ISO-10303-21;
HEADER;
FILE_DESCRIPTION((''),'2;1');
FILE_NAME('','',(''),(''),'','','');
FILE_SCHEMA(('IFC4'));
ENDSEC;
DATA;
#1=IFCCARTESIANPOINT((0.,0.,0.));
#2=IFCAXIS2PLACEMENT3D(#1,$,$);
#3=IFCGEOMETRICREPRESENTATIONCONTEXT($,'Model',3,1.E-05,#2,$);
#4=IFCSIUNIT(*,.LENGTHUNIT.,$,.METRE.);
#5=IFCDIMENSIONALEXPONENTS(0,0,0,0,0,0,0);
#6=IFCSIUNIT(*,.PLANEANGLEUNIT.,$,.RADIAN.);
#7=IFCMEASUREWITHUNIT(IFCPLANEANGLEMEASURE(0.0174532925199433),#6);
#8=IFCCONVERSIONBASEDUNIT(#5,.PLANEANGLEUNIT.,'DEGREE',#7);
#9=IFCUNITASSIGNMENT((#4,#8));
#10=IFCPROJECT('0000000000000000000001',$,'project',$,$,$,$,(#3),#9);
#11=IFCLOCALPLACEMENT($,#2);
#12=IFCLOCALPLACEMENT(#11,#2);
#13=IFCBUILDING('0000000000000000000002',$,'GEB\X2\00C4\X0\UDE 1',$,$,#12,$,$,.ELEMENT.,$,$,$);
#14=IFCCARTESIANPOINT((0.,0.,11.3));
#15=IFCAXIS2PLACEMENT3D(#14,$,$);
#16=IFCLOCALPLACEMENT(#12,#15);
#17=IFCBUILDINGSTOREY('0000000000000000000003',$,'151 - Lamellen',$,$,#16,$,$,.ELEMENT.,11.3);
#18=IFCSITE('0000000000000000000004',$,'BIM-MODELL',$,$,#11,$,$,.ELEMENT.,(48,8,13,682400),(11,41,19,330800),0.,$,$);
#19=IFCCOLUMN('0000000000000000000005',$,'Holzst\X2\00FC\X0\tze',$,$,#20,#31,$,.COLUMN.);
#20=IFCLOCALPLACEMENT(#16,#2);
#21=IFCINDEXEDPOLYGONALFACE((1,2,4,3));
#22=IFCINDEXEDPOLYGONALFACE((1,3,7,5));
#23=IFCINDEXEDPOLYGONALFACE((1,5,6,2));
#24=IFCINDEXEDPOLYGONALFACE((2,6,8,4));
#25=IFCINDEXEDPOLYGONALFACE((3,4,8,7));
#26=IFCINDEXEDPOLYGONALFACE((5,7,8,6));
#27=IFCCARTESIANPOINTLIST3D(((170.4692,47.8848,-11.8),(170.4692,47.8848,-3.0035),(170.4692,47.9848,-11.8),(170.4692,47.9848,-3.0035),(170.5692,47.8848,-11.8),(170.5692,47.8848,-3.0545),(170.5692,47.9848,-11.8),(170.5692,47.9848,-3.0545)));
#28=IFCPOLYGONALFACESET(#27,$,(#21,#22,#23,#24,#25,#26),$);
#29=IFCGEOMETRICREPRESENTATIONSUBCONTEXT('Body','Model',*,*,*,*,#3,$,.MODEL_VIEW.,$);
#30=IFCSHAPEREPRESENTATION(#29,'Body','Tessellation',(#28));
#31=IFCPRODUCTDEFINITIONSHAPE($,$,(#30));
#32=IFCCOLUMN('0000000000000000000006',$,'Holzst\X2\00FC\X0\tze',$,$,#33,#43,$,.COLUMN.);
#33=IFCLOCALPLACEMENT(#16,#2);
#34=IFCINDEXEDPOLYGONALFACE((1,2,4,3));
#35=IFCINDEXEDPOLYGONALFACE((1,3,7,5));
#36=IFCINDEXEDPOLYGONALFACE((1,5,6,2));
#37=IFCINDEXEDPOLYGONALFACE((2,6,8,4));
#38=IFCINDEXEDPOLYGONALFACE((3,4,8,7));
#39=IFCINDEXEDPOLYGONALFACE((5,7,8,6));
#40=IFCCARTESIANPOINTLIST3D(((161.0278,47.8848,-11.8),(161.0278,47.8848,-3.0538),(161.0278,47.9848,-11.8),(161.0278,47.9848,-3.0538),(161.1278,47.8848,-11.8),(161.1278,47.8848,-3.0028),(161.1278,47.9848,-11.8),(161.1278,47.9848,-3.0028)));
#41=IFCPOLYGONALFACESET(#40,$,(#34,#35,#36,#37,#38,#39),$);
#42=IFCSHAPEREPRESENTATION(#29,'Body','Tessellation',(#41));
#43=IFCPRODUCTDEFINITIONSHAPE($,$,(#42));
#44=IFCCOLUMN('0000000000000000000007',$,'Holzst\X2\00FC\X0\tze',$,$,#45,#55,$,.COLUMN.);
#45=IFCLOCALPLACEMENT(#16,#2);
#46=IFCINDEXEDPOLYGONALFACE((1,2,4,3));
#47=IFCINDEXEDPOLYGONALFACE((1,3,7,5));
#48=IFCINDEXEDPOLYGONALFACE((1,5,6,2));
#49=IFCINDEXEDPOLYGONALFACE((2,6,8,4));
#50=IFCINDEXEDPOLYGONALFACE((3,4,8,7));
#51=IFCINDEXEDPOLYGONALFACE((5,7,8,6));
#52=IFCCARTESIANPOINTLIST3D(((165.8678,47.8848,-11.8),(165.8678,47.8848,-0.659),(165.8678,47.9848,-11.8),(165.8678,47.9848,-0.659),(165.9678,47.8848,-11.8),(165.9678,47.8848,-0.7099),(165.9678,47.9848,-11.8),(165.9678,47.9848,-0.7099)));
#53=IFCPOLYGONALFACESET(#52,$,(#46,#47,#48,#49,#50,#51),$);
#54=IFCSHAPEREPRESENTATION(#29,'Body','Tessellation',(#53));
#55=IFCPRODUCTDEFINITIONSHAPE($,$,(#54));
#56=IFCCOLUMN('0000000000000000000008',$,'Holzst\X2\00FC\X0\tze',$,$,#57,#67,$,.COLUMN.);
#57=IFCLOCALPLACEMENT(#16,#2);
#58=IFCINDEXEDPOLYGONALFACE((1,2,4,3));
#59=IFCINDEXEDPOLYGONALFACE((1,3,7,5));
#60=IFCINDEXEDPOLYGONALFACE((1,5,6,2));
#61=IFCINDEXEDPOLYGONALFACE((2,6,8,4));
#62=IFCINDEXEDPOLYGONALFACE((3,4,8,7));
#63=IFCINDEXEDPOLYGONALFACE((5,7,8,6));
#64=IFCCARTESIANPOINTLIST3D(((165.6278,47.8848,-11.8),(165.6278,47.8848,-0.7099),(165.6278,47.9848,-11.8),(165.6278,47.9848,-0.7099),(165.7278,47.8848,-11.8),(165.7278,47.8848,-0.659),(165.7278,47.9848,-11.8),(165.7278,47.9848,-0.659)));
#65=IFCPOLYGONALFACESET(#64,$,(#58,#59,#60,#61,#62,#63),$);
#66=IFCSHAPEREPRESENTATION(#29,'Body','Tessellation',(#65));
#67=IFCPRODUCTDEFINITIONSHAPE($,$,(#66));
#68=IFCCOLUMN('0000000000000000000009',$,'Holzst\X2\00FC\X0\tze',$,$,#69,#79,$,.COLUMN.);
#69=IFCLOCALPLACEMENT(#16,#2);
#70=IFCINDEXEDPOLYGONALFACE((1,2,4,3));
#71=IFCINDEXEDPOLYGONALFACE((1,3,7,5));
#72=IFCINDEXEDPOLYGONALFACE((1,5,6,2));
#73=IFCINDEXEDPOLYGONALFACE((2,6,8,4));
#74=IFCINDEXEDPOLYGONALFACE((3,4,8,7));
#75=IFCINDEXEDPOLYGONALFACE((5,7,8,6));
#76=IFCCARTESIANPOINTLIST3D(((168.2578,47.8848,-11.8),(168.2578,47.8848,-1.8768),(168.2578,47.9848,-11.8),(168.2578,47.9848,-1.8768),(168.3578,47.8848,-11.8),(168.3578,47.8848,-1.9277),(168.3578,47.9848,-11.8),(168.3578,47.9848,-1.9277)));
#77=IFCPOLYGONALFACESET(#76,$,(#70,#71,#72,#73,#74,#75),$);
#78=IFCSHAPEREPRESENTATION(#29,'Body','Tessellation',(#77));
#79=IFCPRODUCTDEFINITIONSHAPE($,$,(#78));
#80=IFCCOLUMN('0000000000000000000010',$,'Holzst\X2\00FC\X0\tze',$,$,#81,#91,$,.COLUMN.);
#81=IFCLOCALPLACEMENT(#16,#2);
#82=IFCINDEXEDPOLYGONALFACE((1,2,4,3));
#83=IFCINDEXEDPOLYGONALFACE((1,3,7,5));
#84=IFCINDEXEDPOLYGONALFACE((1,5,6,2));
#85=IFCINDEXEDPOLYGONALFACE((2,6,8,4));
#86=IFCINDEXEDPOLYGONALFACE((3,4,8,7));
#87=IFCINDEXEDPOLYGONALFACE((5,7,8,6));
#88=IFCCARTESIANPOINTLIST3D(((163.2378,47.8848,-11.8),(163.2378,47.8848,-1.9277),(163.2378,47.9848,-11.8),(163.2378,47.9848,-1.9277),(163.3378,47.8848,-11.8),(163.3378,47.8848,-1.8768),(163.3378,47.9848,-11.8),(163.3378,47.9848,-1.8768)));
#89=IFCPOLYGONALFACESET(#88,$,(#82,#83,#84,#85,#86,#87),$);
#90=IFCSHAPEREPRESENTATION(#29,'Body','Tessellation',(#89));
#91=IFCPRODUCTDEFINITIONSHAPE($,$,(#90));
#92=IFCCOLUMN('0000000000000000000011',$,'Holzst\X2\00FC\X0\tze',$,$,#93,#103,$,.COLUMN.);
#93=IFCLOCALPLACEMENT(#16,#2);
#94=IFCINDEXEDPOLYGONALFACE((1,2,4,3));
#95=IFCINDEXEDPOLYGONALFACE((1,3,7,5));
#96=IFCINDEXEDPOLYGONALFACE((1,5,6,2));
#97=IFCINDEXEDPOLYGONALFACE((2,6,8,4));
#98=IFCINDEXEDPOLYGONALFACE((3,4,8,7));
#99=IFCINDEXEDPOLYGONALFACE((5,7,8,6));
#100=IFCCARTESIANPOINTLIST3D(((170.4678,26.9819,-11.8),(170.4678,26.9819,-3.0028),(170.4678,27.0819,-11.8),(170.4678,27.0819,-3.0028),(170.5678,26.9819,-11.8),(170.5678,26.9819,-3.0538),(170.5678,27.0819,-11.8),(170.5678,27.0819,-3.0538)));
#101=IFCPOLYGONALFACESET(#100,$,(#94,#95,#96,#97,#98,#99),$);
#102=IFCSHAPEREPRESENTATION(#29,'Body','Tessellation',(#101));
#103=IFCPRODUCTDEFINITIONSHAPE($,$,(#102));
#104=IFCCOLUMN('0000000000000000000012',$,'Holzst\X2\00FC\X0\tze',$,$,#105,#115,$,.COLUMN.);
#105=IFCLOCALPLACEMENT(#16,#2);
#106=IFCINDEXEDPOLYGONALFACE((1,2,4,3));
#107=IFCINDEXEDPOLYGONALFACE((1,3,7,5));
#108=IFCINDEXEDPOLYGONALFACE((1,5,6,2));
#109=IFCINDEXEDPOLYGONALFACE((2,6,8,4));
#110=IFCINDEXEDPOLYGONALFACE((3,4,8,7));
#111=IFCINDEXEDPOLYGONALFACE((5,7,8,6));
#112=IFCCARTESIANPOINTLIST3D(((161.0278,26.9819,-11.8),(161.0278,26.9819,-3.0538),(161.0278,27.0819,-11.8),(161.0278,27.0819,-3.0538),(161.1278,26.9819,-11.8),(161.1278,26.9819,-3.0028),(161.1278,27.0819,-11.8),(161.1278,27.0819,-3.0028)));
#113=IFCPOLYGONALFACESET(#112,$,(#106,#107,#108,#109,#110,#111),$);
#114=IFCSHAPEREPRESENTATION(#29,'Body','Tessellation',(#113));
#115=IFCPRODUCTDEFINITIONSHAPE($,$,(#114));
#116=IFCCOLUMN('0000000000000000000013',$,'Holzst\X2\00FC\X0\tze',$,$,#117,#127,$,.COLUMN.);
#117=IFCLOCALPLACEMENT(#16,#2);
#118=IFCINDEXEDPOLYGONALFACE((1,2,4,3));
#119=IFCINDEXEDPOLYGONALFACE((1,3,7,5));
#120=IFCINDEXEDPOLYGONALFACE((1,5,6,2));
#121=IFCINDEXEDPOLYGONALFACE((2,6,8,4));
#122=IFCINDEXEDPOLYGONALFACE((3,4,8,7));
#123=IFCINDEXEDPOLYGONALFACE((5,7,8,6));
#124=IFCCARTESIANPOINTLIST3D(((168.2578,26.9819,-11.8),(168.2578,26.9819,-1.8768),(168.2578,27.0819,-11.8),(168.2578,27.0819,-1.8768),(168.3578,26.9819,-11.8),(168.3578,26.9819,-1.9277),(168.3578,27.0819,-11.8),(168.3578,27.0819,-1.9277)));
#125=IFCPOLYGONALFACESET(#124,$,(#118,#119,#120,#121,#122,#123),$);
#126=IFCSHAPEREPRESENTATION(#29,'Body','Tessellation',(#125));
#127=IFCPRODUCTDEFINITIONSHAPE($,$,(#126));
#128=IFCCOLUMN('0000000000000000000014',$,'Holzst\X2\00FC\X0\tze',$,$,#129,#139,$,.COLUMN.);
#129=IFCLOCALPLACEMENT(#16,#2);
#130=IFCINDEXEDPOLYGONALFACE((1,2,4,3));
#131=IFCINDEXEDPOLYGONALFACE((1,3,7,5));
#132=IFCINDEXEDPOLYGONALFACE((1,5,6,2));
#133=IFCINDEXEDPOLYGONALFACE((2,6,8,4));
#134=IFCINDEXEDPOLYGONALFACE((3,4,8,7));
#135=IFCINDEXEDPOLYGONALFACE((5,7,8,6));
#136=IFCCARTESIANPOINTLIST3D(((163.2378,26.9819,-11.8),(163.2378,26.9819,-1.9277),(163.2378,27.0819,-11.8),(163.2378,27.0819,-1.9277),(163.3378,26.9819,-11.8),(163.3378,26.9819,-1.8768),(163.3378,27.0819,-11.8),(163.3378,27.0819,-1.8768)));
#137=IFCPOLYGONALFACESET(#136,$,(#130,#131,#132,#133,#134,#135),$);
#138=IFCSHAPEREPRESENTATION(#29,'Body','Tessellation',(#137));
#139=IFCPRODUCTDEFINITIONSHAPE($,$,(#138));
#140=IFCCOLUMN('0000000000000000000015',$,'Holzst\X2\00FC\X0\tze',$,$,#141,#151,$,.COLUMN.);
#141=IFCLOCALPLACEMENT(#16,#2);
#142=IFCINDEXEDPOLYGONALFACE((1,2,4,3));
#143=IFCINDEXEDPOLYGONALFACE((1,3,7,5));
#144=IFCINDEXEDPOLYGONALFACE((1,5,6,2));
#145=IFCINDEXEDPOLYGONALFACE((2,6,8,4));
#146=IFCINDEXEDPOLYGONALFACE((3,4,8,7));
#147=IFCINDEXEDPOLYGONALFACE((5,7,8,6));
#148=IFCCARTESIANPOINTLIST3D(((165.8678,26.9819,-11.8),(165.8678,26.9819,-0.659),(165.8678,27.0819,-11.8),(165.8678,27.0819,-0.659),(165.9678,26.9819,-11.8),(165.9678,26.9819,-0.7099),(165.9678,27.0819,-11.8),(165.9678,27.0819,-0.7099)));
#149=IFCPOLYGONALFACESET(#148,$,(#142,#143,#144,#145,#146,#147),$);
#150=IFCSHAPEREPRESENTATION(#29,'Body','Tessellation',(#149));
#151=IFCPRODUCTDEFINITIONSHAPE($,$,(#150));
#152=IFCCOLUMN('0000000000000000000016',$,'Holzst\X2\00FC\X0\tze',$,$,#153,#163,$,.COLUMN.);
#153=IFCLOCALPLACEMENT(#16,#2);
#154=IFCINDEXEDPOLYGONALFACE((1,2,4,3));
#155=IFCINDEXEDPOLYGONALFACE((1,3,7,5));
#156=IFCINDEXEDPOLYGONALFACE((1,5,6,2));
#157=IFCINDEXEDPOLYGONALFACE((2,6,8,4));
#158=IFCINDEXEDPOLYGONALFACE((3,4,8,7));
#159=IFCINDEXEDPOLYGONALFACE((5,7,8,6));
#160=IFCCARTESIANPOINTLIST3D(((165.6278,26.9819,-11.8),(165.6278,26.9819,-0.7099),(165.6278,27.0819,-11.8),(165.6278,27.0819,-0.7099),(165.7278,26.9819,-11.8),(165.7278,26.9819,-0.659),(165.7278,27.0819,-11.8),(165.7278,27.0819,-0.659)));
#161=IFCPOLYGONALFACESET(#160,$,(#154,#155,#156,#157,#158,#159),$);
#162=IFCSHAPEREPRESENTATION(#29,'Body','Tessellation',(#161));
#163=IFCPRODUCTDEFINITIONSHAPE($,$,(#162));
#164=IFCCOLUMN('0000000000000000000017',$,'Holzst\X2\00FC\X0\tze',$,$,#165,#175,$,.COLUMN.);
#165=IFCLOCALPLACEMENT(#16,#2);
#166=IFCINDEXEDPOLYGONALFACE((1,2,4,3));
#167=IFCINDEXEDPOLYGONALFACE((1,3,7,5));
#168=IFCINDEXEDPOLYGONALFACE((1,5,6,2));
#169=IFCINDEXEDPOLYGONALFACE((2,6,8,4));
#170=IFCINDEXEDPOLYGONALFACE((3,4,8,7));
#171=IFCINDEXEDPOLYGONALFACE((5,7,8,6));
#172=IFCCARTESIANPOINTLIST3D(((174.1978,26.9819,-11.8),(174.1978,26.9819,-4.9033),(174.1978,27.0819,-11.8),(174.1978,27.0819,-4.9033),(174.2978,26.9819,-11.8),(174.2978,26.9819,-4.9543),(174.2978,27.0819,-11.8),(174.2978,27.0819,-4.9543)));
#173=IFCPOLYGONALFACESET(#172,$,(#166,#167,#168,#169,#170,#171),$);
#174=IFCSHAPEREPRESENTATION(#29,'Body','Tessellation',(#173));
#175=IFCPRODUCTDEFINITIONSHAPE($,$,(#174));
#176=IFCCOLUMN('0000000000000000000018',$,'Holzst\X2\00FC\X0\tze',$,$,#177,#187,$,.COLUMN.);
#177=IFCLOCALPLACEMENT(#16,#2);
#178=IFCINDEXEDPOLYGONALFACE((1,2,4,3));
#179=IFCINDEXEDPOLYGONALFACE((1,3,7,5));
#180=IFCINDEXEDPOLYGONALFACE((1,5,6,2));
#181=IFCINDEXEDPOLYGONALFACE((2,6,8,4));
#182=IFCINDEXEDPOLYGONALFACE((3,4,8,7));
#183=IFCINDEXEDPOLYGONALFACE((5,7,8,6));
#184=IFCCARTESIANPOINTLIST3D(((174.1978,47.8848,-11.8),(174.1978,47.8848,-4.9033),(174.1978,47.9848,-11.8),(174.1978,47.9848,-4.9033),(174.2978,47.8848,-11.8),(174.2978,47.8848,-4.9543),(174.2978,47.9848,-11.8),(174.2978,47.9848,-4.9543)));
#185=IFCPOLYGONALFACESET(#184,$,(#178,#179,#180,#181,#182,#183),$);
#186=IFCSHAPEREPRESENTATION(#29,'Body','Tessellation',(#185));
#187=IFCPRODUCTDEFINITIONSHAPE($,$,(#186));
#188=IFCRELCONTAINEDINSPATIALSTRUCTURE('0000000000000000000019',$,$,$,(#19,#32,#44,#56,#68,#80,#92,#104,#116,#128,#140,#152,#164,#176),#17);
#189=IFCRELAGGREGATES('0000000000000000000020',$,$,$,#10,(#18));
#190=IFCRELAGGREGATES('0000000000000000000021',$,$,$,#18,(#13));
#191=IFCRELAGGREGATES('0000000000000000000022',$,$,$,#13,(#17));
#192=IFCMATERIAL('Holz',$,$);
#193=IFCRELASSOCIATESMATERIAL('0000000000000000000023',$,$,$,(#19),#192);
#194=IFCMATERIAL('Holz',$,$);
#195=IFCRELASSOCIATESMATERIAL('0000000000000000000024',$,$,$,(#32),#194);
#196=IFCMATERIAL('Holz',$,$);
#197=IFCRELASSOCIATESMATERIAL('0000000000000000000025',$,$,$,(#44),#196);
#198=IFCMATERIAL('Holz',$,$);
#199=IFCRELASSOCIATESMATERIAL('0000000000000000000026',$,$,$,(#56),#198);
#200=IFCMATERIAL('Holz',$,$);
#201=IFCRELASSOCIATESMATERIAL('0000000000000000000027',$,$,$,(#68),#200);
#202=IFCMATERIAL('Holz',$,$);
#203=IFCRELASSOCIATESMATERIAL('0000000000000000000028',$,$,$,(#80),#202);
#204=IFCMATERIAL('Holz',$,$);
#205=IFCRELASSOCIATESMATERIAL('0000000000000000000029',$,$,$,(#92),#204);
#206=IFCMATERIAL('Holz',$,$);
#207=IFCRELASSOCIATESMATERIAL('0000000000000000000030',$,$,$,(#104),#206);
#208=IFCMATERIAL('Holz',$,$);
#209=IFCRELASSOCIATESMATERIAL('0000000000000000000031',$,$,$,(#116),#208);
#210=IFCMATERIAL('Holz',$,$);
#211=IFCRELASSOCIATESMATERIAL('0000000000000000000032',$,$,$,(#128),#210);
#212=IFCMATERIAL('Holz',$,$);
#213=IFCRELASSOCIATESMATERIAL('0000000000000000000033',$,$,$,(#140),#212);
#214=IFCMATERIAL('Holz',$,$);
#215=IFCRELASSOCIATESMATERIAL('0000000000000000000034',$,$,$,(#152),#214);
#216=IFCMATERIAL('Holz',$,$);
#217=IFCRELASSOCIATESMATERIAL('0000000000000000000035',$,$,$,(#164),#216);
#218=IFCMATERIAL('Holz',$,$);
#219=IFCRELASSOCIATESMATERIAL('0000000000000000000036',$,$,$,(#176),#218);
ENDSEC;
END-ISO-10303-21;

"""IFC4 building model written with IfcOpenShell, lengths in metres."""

from ifc_helpers import new_model, entity, si_unit, converted_unit, frame, frame_2d, origin, origin_with_axes, place, context, subcontext, project, spatial, rectangle, extrude, clip, halfspace, material, element, save


model = new_model("IFC4")

# Units and contexts
model_context = context("Model", 3, precision=1e-05, world=origin())
body_context = subcontext(model_context, "Body", "Model", "MODEL_VIEW")
ifc_project = project(units=[si_unit("LENGTHUNIT", "METRE"), converted_unit("PLANEANGLEUNIT", "DEGREE", entity("IfcPlaneAngleMeasure", 0.0174532925199433), si_unit("PLANEANGLEUNIT", "RADIAN"), dimensions=[0, 0, 0, 0, 0, 0, 0])], contexts=[model_context])

# Site, building, storey
site_placement = place(None, origin())
site = spatial("IfcSite", under=ifc_project, at=site_placement, Name="BIM-MODELL", CompositionType="ELEMENT", RefLatitude=(48, 8, 13, 682400), RefLongitude=(11, 41, 19, 330800), RefElevation=0.0)
building_placement = place(site_placement, origin())
building = spatial("IfcBuilding", under=site, at=building_placement, Name="GEBÄUDE 1", CompositionType="ELEMENT")
storey_placement = place(building_placement, frame((0.0, 0.0, 11.3)))
storey = spatial("IfcBuildingStorey", under=building, at=storey_placement, Name="151 - Lamellen", CompositionType="ELEMENT", Elevation=11.3)

# Columns
ifc_material_1 = material(Name="Holz")
column_1_placement = place(storey_placement, frame((170.5692, 47.8848, -11.8)))
element("IfcColumn", 1, at=column_1_placement, inside=storey, material=ifc_material_1, Name="Holzstütze", PredefinedType="COLUMN", context=body_context, shape_type="Clipping", body=[
    clip(extrude(rectangle(XDim=0.1, YDim=0.1, at=frame_2d((-0.05, 0.05), x_axis=(0.0, 1.0))), origin_with_axes(), (0.0, 0.0, 1.0), 8.7965), halfspace(frame((-0.05, 0.05, 8.771), z_axis=(-0.45399, 0.0, -0.891007), x_axis=(0.0, 1.0, 0.0)), True)),
])
ifc_material_2 = material(Name="Holz")
column_2_placement = place(storey_placement, frame((161.1278, 47.8848, -11.8)))
element("IfcColumn", 2, at=column_2_placement, inside=storey, material=ifc_material_2, Name="Holzstütze", PredefinedType="COLUMN", context=body_context, shape_type="Clipping", body=[
    clip(extrude(rectangle(XDim=0.1, YDim=0.1, at=frame_2d((-0.05, 0.05), x_axis=(0.0, 1.0))), origin_with_axes(), (0.0, 0.0, 1.0), 8.7972), halfspace(frame((-0.05, 0.05, 8.7717), z_axis=(0.45399, 0.0, -0.891007), x_axis=(0.0, 1.0, 0.0)), True)),
])
ifc_material_3 = material(Name="Holz")
column_3_placement = place(storey_placement, frame((165.9678, 47.8848, -11.8)))
element("IfcColumn", 3, at=column_3_placement, inside=storey, material=ifc_material_3, Name="Holzstütze", PredefinedType="COLUMN", context=body_context, shape_type="Clipping", body=[
    clip(extrude(rectangle(XDim=0.1, YDim=0.1, at=frame_2d((-0.05, 0.05), x_axis=(0.0, 1.0))), origin_with_axes(), (0.0, 0.0, 1.0), 11.141), halfspace(frame((-0.05, 0.05, 11.1155), z_axis=(-0.45399, 0.0, -0.891007), x_axis=(0.0, 1.0, 0.0)), True)),
])
ifc_material_4 = material(Name="Holz")
column_4_placement = place(storey_placement, frame((165.7278, 47.8848, -11.8)))
element("IfcColumn", 4, at=column_4_placement, inside=storey, material=ifc_material_4, Name="Holzstütze", PredefinedType="COLUMN", context=body_context, shape_type="Clipping", body=[
    clip(extrude(rectangle(XDim=0.1, YDim=0.1, at=frame_2d((-0.05, 0.05), x_axis=(0.0, 1.0))), origin_with_axes(), (0.0, 0.0, 1.0), 11.141), halfspace(frame((-0.05, 0.05, 11.1155), z_axis=(0.45399, 0.0, -0.891007), x_axis=(0.0, 1.0, 0.0)), True)),
])
ifc_material_5 = material(Name="Holz")
column_5_placement = place(storey_placement, frame((168.3578, 47.8848, -11.8)))
element("IfcColumn", 5, at=column_5_placement, inside=storey, material=ifc_material_5, Name="Holzstütze", PredefinedType="COLUMN", context=body_context, shape_type="Clipping", body=[
    clip(extrude(rectangle(XDim=0.1, YDim=0.1, at=frame_2d((-0.05, 0.05), x_axis=(0.0, 1.0))), origin_with_axes(), (0.0, 0.0, 1.0), 9.9232), halfspace(frame((-0.05, 0.05, 9.8978), z_axis=(-0.45399, 0.0, -0.891007), x_axis=(0.0, 1.0, 0.0)), True)),
])
ifc_material_6 = material(Name="Holz")
column_6_placement = place(storey_placement, frame((163.3378, 47.8848, -11.8)))
element("IfcColumn", 6, at=column_6_placement, inside=storey, material=ifc_material_6, Name="Holzstütze", PredefinedType="COLUMN", context=body_context, shape_type="Clipping", body=[
    clip(extrude(rectangle(XDim=0.1, YDim=0.1, at=frame_2d((-0.05, 0.05), x_axis=(0.0, 1.0))), origin_with_axes(), (0.0, 0.0, 1.0), 9.9232), halfspace(frame((-0.05, 0.05, 9.8978), z_axis=(0.45399, 0.0, -0.891007), x_axis=(0.0, 1.0, 0.0)), True)),
])
ifc_material_7 = material(Name="Holz")
column_7_placement = place(storey_placement, frame((170.5678, 26.9819, -11.8)))
element("IfcColumn", 7, at=column_7_placement, inside=storey, material=ifc_material_7, Name="Holzstütze", PredefinedType="COLUMN", context=body_context, shape_type="Clipping", body=[
    clip(extrude(rectangle(XDim=0.1, YDim=0.1, at=frame_2d((-0.05, 0.05), x_axis=(0.0, 1.0))), origin_with_axes(), (0.0, 0.0, 1.0), 8.7972), halfspace(frame((-0.05, 0.05, 8.7717), z_axis=(-0.45399, 0.0, -0.891007), x_axis=(0.0, -1.0, 0.0)), True)),
])
ifc_material_8 = material(Name="Holz")
column_8_placement = place(storey_placement, frame((161.1278, 26.9819, -11.8)))
element("IfcColumn", 8, at=column_8_placement, inside=storey, material=ifc_material_8, Name="Holzstütze", PredefinedType="COLUMN", context=body_context, shape_type="Clipping", body=[
    clip(extrude(rectangle(XDim=0.1, YDim=0.1, at=frame_2d((-0.05, 0.05), x_axis=(0.0, 1.0))), origin_with_axes(), (0.0, 0.0, 1.0), 8.7972), halfspace(frame((-0.05, 0.05, 8.7717), z_axis=(0.45399, 0.0, -0.891007), x_axis=(0.0, -1.0, 0.0)), True)),
])
ifc_material_9 = material(Name="Holz")
column_9_placement = place(storey_placement, frame((168.3578, 26.9819, -11.8)))
element("IfcColumn", 9, at=column_9_placement, inside=storey, material=ifc_material_9, Name="Holzstütze", PredefinedType="COLUMN", context=body_context, shape_type="Clipping", body=[
    clip(extrude(rectangle(XDim=0.1, YDim=0.1, at=frame_2d((-0.05, 0.05), x_axis=(0.0, 1.0))), origin_with_axes(), (0.0, 0.0, 1.0), 9.9232), halfspace(frame((-0.05, 0.05, 9.8978), z_axis=(-0.45399, 0.0, -0.891007), x_axis=(0.0, -1.0, 0.0)), True)),
])
ifc_material_10 = material(Name="Holz")
column_10_placement = place(storey_placement, frame((163.3378, 26.9819, -11.8)))
element("IfcColumn", 10, at=column_10_placement, inside=storey, material=ifc_material_10, Name="Holzstütze", PredefinedType="COLUMN", context=body_context, shape_type="Clipping", body=[
    clip(extrude(rectangle(XDim=0.1, YDim=0.1, at=frame_2d((-0.05, 0.05), x_axis=(0.0, 1.0))), origin_with_axes(), (0.0, 0.0, 1.0), 9.9232), halfspace(frame((-0.05, 0.05, 9.8978), z_axis=(0.45399, 0.0, -0.891007), x_axis=(0.0, -1.0, 0.0)), True)),
])
ifc_material_11 = material(Name="Holz")
column_11_placement = place(storey_placement, frame((165.9678, 26.9819, -11.8)))
element("IfcColumn", 11, at=column_11_placement, inside=storey, material=ifc_material_11, Name="Holzstütze", PredefinedType="COLUMN", context=body_context, shape_type="Clipping", body=[
    clip(extrude(rectangle(XDim=0.1, YDim=0.1, at=frame_2d((-0.05, 0.05), x_axis=(0.0, 1.0))), origin_with_axes(), (0.0, 0.0, 1.0), 11.141), halfspace(frame((-0.05, 0.05, 11.1155), z_axis=(-0.45399, 0.0, -0.891007), x_axis=(0.0, -1.0, 0.0)), True)),
])
ifc_material_12 = material(Name="Holz")
column_12_placement = place(storey_placement, frame((165.7278, 26.9819, -11.8)))
element("IfcColumn", 12, at=column_12_placement, inside=storey, material=ifc_material_12, Name="Holzstütze", PredefinedType="COLUMN", context=body_context, shape_type="Clipping", body=[
    clip(extrude(rectangle(XDim=0.1, YDim=0.1, at=frame_2d((-0.05, 0.05), x_axis=(0.0, 1.0))), origin_with_axes(), (0.0, 0.0, 1.0), 11.141), halfspace(frame((-0.05, 0.05, 11.1155), z_axis=(0.45399, 0.0, -0.891007), x_axis=(0.0, -1.0, 0.0)), True)),
])
ifc_material_13 = material(Name="Holz")
column_13_placement = place(storey_placement, frame((174.2978, 26.9819, -11.8)))
element("IfcColumn", 13, at=column_13_placement, inside=storey, material=ifc_material_13, Name="Holzstütze", PredefinedType="COLUMN", context=body_context, shape_type="Clipping", body=[
    clip(extrude(rectangle(XDim=0.1, YDim=0.1, at=frame_2d((-0.05, 0.05), x_axis=(0.0, 1.0))), origin_with_axes(), (0.0, 0.0, 1.0), 6.8967), halfspace(frame((-0.05, 0.05, 6.8712), z_axis=(-0.45399, 0.0, -0.891007), x_axis=(0.0, -1.0, 0.0)), True)),
])
ifc_material_14 = material(Name="Holz")
column_14_placement = place(storey_placement, frame((174.2978, 47.8848, -11.8)))
element("IfcColumn", 14, at=column_14_placement, inside=storey, material=ifc_material_14, Name="Holzstütze", PredefinedType="COLUMN", context=body_context, shape_type="Clipping", body=[
    clip(extrude(rectangle(XDim=0.1, YDim=0.1, at=frame_2d((-0.05, 0.05), x_axis=(0.0, 1.0))), origin_with_axes(), (0.0, 0.0, 1.0), 6.8967), halfspace(frame((-0.05, 0.05, 6.8712), z_axis=(-0.45399, 0.0, -0.891007), x_axis=(0.891007, 0.0, -0.45399)), True)),
])

save(model, "model.ifc")
